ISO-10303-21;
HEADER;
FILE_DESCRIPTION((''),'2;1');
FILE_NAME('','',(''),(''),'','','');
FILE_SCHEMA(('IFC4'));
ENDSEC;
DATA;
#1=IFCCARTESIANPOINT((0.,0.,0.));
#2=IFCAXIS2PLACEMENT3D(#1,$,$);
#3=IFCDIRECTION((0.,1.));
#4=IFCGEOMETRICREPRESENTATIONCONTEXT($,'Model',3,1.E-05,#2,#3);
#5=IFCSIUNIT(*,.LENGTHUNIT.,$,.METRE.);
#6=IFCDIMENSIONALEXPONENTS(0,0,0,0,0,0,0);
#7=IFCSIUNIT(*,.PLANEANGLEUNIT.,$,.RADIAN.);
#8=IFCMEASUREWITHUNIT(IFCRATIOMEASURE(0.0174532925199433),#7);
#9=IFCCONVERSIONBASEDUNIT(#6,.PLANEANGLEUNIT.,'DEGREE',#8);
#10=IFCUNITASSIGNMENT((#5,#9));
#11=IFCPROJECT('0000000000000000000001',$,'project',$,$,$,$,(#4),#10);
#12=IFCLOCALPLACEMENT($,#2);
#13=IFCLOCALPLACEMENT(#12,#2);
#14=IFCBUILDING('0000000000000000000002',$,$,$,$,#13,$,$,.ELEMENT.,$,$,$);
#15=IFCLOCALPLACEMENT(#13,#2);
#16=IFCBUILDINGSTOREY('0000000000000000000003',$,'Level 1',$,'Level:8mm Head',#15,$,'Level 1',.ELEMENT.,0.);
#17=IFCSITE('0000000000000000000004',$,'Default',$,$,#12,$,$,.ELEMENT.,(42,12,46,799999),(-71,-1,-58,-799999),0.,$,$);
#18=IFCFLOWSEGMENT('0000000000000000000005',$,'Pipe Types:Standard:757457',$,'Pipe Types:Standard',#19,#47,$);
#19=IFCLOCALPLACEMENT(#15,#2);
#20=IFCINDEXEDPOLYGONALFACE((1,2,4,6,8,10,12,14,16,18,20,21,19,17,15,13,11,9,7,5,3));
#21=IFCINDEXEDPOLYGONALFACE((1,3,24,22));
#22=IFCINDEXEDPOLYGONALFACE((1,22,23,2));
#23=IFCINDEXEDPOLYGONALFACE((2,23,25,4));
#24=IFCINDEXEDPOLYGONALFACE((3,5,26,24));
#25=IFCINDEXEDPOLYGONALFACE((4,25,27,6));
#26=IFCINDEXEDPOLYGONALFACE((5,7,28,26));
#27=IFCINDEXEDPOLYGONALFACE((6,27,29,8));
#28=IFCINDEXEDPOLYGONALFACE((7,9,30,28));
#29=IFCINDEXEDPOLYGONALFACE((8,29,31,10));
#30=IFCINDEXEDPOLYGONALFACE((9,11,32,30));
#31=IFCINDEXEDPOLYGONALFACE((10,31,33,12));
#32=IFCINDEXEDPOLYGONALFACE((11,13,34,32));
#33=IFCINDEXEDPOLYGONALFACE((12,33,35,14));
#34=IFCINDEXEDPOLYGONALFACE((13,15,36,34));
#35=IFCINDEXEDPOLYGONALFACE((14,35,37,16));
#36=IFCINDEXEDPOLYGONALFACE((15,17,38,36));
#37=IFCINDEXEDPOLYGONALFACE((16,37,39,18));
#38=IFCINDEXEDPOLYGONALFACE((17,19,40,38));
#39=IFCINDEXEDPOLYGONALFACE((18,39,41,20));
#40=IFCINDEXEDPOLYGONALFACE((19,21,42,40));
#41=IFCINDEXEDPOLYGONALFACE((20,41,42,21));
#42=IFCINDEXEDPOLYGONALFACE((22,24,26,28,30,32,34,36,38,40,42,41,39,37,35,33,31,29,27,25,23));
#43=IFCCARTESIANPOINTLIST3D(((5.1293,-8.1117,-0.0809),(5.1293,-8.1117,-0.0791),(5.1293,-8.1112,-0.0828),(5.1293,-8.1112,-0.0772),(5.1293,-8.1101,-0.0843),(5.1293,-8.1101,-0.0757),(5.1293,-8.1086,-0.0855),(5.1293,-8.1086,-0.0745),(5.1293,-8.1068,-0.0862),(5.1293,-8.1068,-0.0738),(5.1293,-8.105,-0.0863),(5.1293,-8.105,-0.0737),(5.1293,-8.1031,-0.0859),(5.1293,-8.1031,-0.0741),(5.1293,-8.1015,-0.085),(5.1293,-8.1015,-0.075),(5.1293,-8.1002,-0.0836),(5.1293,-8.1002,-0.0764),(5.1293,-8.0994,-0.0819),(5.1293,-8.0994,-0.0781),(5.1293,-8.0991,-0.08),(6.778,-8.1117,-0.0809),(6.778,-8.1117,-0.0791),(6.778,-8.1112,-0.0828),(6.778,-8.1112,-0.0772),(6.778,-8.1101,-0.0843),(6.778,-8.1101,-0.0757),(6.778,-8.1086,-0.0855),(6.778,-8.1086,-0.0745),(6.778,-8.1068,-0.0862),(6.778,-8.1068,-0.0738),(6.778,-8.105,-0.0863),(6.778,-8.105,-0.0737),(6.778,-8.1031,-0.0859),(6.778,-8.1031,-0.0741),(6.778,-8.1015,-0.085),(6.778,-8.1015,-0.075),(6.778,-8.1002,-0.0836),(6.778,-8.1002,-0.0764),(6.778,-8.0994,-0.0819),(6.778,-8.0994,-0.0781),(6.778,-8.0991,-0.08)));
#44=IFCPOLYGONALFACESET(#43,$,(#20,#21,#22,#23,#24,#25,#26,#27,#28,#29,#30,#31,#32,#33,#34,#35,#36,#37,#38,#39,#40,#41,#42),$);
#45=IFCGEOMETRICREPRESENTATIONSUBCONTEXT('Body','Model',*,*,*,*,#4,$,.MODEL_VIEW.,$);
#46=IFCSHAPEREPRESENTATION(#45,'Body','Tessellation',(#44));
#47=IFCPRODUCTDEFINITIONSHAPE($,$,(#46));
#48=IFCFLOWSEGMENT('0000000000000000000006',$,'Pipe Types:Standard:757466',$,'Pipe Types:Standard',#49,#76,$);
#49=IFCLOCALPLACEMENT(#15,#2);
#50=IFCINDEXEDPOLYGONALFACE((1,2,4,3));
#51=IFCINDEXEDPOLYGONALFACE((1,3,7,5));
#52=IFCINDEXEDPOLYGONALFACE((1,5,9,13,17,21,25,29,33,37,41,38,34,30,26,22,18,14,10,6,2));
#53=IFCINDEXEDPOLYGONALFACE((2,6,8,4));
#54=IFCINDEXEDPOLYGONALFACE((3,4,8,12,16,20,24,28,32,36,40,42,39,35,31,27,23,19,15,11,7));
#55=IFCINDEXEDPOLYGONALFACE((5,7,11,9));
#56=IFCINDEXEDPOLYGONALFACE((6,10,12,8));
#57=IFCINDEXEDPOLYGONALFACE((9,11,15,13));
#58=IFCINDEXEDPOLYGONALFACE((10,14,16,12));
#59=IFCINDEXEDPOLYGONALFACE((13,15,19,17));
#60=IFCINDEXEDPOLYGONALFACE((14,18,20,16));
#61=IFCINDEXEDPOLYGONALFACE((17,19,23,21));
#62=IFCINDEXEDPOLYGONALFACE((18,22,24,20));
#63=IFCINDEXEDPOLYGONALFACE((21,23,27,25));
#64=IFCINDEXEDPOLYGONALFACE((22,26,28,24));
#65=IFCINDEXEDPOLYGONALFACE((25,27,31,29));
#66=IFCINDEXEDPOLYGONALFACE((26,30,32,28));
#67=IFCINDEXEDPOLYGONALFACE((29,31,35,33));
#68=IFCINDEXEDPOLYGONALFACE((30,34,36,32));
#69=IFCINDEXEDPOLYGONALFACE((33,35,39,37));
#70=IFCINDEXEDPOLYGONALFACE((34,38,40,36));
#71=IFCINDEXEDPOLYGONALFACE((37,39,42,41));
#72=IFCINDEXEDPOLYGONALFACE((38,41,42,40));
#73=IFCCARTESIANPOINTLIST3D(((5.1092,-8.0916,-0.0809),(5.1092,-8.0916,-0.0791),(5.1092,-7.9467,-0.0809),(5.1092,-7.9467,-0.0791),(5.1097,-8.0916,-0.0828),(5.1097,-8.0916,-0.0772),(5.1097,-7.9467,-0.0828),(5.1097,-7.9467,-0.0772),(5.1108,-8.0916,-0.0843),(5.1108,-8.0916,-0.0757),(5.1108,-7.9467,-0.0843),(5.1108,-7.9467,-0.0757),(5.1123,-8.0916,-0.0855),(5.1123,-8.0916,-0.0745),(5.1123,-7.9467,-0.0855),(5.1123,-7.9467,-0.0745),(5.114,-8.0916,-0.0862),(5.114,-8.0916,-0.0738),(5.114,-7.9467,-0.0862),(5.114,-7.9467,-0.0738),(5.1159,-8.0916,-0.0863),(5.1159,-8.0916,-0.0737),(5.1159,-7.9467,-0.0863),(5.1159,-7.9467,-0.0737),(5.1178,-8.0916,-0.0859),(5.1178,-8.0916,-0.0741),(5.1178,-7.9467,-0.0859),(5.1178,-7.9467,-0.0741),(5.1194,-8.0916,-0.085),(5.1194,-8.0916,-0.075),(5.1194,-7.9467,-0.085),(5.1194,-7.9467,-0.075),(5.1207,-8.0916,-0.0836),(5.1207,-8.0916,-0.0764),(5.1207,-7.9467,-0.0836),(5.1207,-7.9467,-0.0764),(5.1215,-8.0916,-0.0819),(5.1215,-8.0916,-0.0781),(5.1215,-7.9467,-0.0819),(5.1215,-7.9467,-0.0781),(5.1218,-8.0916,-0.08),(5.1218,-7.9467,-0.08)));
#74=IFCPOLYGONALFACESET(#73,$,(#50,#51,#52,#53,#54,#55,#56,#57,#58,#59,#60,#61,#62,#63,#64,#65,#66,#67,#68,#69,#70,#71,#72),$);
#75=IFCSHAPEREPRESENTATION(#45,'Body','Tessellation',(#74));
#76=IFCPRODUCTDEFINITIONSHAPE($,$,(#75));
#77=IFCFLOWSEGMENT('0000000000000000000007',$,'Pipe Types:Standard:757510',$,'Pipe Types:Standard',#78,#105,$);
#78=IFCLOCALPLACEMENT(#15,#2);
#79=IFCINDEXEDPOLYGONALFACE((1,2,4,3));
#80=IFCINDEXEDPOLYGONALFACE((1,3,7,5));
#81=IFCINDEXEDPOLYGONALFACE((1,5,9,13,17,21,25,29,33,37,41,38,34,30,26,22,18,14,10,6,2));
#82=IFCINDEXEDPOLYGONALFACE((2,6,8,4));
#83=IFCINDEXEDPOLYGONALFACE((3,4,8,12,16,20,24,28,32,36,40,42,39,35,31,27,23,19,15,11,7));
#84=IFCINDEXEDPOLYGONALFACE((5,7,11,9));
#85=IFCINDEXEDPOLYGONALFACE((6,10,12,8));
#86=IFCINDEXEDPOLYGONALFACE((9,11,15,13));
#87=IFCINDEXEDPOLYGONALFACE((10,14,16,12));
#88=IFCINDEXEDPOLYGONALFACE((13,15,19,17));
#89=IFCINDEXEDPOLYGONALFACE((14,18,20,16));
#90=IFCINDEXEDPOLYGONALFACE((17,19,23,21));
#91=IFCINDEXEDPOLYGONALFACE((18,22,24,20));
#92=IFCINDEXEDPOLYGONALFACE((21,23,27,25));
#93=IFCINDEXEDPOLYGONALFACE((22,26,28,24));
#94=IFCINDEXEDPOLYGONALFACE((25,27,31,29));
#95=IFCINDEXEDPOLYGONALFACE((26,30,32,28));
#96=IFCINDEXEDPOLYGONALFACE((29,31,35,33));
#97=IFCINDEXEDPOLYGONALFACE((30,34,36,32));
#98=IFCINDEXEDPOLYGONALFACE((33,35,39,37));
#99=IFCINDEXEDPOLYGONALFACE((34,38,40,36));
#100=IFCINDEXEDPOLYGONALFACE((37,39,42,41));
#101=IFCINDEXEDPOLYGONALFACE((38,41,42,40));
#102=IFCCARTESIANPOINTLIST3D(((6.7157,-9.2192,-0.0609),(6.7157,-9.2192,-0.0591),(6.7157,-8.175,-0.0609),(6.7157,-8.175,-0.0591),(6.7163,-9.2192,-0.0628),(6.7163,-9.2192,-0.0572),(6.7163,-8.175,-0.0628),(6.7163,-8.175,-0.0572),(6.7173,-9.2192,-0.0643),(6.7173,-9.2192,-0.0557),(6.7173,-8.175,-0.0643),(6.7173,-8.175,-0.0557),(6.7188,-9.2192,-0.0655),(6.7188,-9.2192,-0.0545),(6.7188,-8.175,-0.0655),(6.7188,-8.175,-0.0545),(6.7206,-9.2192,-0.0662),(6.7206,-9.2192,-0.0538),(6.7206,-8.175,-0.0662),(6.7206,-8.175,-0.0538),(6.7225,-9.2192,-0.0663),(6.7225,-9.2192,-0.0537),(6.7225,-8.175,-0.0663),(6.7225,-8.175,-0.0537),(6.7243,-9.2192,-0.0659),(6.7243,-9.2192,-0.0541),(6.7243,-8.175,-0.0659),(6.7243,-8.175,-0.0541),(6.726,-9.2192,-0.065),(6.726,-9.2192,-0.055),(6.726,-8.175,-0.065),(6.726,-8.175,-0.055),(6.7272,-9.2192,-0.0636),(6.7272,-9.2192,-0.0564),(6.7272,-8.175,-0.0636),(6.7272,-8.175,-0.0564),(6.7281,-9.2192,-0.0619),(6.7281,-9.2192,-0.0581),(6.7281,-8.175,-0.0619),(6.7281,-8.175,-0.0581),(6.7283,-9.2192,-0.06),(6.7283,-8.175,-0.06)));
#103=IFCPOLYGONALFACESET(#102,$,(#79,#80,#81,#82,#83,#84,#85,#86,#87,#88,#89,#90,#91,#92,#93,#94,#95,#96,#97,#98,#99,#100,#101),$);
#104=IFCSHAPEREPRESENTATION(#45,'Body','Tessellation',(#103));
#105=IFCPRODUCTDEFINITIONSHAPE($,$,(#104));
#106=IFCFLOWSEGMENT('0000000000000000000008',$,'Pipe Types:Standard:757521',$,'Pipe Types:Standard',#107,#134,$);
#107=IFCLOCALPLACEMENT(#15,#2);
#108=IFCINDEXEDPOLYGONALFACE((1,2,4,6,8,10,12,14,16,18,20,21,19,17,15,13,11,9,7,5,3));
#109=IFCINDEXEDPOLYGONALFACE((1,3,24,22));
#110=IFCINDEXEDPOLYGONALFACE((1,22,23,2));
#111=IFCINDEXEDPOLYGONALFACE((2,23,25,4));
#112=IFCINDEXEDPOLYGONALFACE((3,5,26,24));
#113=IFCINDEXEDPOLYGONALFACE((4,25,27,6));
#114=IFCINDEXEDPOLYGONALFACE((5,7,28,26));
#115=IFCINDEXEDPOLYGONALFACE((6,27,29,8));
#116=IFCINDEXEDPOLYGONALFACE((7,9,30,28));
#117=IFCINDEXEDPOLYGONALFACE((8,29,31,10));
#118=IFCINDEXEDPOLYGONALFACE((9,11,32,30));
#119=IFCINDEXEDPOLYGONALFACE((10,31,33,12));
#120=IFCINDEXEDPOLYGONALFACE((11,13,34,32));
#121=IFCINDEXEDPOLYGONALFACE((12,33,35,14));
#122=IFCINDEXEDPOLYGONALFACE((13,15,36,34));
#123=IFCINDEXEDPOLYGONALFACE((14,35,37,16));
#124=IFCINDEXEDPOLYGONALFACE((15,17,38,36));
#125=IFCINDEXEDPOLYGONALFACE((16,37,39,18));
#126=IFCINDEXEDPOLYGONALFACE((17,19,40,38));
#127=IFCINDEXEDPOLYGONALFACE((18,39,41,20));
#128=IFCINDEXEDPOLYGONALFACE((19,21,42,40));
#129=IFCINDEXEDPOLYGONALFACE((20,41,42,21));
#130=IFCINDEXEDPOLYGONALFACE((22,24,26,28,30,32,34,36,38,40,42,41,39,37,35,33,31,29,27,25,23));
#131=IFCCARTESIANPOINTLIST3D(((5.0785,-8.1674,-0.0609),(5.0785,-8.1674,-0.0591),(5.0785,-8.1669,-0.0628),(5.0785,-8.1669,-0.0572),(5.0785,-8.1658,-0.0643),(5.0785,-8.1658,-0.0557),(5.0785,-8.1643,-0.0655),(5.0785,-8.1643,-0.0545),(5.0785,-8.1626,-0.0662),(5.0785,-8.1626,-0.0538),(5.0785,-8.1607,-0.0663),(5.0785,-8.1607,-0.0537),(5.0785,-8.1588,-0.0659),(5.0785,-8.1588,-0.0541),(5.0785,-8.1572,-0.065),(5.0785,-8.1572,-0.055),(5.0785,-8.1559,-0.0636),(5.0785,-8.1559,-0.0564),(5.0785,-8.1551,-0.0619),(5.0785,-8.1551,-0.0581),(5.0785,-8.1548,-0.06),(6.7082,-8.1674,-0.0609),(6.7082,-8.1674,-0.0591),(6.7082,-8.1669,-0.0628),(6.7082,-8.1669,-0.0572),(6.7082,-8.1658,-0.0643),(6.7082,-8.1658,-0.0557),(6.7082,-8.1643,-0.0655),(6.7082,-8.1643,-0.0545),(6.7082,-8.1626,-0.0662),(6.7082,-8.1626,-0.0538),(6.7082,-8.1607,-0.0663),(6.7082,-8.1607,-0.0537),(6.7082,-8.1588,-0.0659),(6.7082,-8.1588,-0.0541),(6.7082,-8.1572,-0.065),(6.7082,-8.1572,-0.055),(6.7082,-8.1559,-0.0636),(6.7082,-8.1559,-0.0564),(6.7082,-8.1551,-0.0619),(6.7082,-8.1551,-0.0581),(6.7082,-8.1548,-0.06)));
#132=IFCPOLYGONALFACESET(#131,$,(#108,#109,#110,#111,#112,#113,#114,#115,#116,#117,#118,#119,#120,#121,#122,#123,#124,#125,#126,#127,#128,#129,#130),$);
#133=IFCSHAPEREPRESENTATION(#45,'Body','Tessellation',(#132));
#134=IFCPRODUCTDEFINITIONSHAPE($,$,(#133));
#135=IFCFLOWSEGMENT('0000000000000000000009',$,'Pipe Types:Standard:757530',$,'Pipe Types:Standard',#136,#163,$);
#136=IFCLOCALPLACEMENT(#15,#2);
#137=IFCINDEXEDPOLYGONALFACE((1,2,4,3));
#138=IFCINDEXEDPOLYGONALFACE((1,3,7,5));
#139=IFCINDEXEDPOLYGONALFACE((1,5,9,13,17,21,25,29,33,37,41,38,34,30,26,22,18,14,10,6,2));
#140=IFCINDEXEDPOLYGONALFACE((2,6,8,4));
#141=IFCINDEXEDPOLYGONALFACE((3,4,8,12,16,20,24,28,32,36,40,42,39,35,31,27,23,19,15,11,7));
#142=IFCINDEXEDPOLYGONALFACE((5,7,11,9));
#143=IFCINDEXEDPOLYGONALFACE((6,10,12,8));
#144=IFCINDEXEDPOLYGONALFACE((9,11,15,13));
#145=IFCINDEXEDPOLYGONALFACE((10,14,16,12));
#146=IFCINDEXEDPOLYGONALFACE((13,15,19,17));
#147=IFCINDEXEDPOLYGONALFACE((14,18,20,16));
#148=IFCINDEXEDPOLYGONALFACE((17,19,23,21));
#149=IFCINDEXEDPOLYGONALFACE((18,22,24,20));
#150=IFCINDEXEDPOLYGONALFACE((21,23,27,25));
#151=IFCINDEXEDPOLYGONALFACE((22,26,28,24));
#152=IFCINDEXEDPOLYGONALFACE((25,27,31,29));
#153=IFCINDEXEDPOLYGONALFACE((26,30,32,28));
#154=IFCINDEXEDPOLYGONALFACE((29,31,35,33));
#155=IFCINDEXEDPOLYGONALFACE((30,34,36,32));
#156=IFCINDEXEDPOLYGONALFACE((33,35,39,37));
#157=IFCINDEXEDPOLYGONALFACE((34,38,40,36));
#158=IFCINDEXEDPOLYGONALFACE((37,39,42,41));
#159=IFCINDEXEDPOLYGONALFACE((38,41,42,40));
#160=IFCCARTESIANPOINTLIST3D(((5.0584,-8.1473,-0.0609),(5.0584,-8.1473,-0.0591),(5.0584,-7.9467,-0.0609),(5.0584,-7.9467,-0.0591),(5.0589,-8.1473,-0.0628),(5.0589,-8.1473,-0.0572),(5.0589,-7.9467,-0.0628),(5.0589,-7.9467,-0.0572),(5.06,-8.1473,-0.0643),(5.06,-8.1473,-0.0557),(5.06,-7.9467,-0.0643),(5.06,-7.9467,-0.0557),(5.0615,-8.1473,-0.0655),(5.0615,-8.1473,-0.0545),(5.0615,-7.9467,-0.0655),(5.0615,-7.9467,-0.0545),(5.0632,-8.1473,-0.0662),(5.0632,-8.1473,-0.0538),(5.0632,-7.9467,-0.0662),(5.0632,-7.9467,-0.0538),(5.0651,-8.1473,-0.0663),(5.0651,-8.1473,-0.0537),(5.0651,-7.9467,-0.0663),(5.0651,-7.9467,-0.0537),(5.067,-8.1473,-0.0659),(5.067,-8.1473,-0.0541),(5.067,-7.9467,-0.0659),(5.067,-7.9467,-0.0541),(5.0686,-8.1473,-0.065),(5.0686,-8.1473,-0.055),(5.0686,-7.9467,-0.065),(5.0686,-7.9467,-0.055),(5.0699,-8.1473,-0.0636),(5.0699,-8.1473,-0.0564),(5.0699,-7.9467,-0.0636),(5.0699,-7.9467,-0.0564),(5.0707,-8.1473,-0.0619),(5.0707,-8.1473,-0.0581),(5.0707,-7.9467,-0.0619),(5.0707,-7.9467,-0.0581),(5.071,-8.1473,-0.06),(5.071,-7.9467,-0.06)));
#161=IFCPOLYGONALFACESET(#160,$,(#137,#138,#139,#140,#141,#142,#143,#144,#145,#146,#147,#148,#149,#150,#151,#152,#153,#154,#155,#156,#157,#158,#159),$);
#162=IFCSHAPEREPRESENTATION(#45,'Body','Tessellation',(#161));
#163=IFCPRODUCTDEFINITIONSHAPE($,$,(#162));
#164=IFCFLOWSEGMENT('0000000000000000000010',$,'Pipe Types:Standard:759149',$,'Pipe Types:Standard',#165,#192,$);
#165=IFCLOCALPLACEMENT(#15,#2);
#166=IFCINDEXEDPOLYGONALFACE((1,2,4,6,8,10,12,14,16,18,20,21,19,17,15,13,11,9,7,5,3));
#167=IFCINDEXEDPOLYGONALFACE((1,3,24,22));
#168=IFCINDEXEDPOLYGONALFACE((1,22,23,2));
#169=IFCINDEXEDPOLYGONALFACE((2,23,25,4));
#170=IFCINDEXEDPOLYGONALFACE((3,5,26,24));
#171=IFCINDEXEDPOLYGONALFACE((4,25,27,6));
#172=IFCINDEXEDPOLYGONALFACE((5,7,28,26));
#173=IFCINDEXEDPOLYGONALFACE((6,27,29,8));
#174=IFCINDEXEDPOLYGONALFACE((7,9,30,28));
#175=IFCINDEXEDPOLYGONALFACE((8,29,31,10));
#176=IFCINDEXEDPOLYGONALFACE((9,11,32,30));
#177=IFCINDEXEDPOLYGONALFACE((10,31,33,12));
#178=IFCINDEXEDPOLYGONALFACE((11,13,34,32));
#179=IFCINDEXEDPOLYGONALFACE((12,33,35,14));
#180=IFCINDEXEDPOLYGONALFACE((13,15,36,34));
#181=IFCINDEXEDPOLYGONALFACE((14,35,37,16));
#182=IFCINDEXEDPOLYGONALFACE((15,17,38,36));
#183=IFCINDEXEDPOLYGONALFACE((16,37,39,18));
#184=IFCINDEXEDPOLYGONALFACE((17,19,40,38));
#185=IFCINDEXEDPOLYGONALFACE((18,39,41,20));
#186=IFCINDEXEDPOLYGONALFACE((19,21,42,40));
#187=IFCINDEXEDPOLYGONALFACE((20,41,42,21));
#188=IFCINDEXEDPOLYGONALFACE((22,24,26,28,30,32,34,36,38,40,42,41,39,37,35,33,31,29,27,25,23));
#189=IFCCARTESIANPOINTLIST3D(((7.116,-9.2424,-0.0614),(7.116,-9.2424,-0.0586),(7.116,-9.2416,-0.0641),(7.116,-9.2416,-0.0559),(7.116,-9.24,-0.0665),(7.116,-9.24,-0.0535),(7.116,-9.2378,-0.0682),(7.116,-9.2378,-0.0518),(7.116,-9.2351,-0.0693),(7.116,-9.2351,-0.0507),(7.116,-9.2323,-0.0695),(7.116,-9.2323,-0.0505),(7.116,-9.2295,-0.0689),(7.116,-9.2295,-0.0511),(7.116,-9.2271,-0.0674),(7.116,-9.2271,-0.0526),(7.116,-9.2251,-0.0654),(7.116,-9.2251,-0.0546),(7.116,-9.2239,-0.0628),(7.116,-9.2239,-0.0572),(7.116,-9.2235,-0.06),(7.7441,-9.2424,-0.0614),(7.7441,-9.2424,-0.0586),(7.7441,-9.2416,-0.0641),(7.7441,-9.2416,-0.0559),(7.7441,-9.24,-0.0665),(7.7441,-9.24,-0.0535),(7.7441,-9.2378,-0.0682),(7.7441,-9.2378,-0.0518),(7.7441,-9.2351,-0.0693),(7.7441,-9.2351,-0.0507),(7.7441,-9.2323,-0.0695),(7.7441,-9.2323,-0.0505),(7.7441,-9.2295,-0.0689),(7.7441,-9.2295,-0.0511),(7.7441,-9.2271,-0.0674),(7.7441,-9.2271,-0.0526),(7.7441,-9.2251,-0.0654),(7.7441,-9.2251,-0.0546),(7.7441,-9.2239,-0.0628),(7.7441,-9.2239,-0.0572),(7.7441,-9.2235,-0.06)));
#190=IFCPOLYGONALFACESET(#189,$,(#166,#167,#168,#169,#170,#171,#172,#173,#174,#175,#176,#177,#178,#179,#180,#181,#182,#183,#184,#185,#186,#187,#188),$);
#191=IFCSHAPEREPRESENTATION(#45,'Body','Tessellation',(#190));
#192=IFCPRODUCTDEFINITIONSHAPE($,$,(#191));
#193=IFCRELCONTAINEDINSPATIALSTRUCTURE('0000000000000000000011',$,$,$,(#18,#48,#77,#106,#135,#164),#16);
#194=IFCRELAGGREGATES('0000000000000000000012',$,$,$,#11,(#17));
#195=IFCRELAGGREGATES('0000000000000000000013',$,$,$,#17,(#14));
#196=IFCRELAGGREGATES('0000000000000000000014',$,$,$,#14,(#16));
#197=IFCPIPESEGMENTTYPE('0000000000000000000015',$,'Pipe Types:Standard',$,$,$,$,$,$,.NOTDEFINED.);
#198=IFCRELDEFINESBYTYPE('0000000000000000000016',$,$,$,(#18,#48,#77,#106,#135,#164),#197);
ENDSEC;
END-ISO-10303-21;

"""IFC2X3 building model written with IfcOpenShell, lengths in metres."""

from ifc_helpers import new_model, entity, si_unit, converted_unit, direction, frame, frame_2d, origin, origin_2d_with_axis, place, context, subcontext, project, spatial, circle, extrude, type_object, element, save


model = new_model("IFC2X3")

# Units and contexts
model_context = context("Model", 3, precision=1e-05, world=origin(), true_north=direction((0.0, 1.0)))
body_context = subcontext(model_context, "Body", "Model", "MODEL_VIEW")
ifc_project = project(units=[si_unit("LENGTHUNIT", "METRE"), converted_unit("PLANEANGLEUNIT", "DEGREE", entity("IfcRatioMeasure", 0.0174532925199433), si_unit("PLANEANGLEUNIT", "RADIAN"), dimensions=[0, 0, 0, 0, 0, 0, 0])], contexts=[model_context])

# Site, building, storey
site_placement = place(None, origin())
site = spatial("IfcSite", under=ifc_project, at=site_placement, Name="Default", CompositionType="ELEMENT", RefLatitude=(42, 12, 46, 799999), RefLongitude=(-71, -1, -58, -799999), RefElevation=0.0)
building_placement = place(site_placement, origin())
building = spatial("IfcBuilding", under=site, at=building_placement, CompositionType="ELEMENT")
storey_placement = place(building_placement, origin())
storey = spatial("IfcBuildingStorey", under=building, at=storey_placement, Name="Level 1", ObjectType="Level:8mm Head", LongName="Level 1", CompositionType="ELEMENT", Elevation=0.0)

# Flow segments
pipe_segment_type = type_object("IfcPipeSegmentType", Name="Pipe Types:Standard", PredefinedType="NOTDEFINED")
flow_segment_1_placement = place(storey_placement, origin())
element("IfcFlowSegment", 1, at=flow_segment_1_placement, inside=storey, type_object=pipe_segment_type, Name="Pipe Types:Standard:757457", ObjectType="Pipe Types:Standard", context=body_context, shape_type="SweptSolid", body=[
    extrude(circle(Radius=0.0063, at=frame_2d((0.0, 0.0), x_axis=(1.0, 0.0))), frame((5.1293, -8.1054, -0.08), z_axis=(1.0, 0.0, 0.0), x_axis=(0.0, 1.0, 0.0)), (0.0, 0.0, 1.0), 1.6488),
])
flow_segment_2_placement = place(storey_placement, origin())
element("IfcFlowSegment", 2, at=flow_segment_2_placement, inside=storey, type_object=pipe_segment_type, Name="Pipe Types:Standard:757466", ObjectType="Pipe Types:Standard", context=body_context, shape_type="SweptSolid", body=[
    extrude(circle(Radius=0.0063, at=origin_2d_with_axis()), frame((5.1155, -8.0916, -0.08), z_axis=(0.0, 1.0, 0.0), x_axis=(1.0, 0.0, 0.0)), (0.0, 0.0, 1.0), 0.1449),
])
flow_segment_3_placement = place(storey_placement, origin())
element("IfcFlowSegment", 3, at=flow_segment_3_placement, inside=storey, type_object=pipe_segment_type, Name="Pipe Types:Standard:757510", ObjectType="Pipe Types:Standard", context=body_context, shape_type="SweptSolid", body=[
    extrude(circle(Radius=0.0063, at=frame_2d((0.0, 0.0), x_axis=(1.0, 0.0))), frame((6.722, -9.2192, -0.06), z_axis=(0.0, 1.0, 0.0), x_axis=(1.0, 0.0, 0.0)), (0.0, 0.0, 1.0), 1.0442),
])
flow_segment_4_placement = place(storey_placement, origin())
element("IfcFlowSegment", 4, at=flow_segment_4_placement, inside=storey, type_object=pipe_segment_type, Name="Pipe Types:Standard:757521", ObjectType="Pipe Types:Standard", context=body_context, shape_type="SweptSolid", body=[
    extrude(circle(Radius=0.0063, at=frame_2d((0.0, 0.0), x_axis=(1.0, 0.0))), frame((5.0785, -8.1612, -0.06), z_axis=(1.0, 0.0, 0.0), x_axis=(0.0, 1.0, 0.0)), (0.0, 0.0, 1.0), 1.6297),
])
flow_segment_5_placement = place(storey_placement, origin())
element("IfcFlowSegment", 5, at=flow_segment_5_placement, inside=storey, type_object=pipe_segment_type, Name="Pipe Types:Standard:757530", ObjectType="Pipe Types:Standard", context=body_context, shape_type="SweptSolid", body=[
    extrude(circle(Radius=0.0063, at=frame_2d((0.0, 0.0), x_axis=(1.0, 0.0))), frame((5.0647, -8.1473, -0.06), z_axis=(0.0, 1.0, 0.0), x_axis=(1.0, 0.0, 0.0)), (0.0, 0.0, 1.0), 0.2006),
])
flow_segment_6_placement = place(storey_placement, origin())
element("IfcFlowSegment", 6, at=flow_segment_6_placement, inside=storey, type_object=pipe_segment_type, Name="Pipe Types:Standard:759149", ObjectType="Pipe Types:Standard", context=body_context, shape_type="SweptSolid", body=[
    extrude(circle(Radius=0.0095, at=frame_2d((0.0, 0.0), x_axis=(1.0, 0.0))), frame((7.116, -9.233, -0.06), z_axis=(1.0, 0.0, 0.0), x_axis=(0.0, 1.0, 0.0)), (0.0, 0.0, 1.0), 0.6281),
])

save(model, "model.ifc")
